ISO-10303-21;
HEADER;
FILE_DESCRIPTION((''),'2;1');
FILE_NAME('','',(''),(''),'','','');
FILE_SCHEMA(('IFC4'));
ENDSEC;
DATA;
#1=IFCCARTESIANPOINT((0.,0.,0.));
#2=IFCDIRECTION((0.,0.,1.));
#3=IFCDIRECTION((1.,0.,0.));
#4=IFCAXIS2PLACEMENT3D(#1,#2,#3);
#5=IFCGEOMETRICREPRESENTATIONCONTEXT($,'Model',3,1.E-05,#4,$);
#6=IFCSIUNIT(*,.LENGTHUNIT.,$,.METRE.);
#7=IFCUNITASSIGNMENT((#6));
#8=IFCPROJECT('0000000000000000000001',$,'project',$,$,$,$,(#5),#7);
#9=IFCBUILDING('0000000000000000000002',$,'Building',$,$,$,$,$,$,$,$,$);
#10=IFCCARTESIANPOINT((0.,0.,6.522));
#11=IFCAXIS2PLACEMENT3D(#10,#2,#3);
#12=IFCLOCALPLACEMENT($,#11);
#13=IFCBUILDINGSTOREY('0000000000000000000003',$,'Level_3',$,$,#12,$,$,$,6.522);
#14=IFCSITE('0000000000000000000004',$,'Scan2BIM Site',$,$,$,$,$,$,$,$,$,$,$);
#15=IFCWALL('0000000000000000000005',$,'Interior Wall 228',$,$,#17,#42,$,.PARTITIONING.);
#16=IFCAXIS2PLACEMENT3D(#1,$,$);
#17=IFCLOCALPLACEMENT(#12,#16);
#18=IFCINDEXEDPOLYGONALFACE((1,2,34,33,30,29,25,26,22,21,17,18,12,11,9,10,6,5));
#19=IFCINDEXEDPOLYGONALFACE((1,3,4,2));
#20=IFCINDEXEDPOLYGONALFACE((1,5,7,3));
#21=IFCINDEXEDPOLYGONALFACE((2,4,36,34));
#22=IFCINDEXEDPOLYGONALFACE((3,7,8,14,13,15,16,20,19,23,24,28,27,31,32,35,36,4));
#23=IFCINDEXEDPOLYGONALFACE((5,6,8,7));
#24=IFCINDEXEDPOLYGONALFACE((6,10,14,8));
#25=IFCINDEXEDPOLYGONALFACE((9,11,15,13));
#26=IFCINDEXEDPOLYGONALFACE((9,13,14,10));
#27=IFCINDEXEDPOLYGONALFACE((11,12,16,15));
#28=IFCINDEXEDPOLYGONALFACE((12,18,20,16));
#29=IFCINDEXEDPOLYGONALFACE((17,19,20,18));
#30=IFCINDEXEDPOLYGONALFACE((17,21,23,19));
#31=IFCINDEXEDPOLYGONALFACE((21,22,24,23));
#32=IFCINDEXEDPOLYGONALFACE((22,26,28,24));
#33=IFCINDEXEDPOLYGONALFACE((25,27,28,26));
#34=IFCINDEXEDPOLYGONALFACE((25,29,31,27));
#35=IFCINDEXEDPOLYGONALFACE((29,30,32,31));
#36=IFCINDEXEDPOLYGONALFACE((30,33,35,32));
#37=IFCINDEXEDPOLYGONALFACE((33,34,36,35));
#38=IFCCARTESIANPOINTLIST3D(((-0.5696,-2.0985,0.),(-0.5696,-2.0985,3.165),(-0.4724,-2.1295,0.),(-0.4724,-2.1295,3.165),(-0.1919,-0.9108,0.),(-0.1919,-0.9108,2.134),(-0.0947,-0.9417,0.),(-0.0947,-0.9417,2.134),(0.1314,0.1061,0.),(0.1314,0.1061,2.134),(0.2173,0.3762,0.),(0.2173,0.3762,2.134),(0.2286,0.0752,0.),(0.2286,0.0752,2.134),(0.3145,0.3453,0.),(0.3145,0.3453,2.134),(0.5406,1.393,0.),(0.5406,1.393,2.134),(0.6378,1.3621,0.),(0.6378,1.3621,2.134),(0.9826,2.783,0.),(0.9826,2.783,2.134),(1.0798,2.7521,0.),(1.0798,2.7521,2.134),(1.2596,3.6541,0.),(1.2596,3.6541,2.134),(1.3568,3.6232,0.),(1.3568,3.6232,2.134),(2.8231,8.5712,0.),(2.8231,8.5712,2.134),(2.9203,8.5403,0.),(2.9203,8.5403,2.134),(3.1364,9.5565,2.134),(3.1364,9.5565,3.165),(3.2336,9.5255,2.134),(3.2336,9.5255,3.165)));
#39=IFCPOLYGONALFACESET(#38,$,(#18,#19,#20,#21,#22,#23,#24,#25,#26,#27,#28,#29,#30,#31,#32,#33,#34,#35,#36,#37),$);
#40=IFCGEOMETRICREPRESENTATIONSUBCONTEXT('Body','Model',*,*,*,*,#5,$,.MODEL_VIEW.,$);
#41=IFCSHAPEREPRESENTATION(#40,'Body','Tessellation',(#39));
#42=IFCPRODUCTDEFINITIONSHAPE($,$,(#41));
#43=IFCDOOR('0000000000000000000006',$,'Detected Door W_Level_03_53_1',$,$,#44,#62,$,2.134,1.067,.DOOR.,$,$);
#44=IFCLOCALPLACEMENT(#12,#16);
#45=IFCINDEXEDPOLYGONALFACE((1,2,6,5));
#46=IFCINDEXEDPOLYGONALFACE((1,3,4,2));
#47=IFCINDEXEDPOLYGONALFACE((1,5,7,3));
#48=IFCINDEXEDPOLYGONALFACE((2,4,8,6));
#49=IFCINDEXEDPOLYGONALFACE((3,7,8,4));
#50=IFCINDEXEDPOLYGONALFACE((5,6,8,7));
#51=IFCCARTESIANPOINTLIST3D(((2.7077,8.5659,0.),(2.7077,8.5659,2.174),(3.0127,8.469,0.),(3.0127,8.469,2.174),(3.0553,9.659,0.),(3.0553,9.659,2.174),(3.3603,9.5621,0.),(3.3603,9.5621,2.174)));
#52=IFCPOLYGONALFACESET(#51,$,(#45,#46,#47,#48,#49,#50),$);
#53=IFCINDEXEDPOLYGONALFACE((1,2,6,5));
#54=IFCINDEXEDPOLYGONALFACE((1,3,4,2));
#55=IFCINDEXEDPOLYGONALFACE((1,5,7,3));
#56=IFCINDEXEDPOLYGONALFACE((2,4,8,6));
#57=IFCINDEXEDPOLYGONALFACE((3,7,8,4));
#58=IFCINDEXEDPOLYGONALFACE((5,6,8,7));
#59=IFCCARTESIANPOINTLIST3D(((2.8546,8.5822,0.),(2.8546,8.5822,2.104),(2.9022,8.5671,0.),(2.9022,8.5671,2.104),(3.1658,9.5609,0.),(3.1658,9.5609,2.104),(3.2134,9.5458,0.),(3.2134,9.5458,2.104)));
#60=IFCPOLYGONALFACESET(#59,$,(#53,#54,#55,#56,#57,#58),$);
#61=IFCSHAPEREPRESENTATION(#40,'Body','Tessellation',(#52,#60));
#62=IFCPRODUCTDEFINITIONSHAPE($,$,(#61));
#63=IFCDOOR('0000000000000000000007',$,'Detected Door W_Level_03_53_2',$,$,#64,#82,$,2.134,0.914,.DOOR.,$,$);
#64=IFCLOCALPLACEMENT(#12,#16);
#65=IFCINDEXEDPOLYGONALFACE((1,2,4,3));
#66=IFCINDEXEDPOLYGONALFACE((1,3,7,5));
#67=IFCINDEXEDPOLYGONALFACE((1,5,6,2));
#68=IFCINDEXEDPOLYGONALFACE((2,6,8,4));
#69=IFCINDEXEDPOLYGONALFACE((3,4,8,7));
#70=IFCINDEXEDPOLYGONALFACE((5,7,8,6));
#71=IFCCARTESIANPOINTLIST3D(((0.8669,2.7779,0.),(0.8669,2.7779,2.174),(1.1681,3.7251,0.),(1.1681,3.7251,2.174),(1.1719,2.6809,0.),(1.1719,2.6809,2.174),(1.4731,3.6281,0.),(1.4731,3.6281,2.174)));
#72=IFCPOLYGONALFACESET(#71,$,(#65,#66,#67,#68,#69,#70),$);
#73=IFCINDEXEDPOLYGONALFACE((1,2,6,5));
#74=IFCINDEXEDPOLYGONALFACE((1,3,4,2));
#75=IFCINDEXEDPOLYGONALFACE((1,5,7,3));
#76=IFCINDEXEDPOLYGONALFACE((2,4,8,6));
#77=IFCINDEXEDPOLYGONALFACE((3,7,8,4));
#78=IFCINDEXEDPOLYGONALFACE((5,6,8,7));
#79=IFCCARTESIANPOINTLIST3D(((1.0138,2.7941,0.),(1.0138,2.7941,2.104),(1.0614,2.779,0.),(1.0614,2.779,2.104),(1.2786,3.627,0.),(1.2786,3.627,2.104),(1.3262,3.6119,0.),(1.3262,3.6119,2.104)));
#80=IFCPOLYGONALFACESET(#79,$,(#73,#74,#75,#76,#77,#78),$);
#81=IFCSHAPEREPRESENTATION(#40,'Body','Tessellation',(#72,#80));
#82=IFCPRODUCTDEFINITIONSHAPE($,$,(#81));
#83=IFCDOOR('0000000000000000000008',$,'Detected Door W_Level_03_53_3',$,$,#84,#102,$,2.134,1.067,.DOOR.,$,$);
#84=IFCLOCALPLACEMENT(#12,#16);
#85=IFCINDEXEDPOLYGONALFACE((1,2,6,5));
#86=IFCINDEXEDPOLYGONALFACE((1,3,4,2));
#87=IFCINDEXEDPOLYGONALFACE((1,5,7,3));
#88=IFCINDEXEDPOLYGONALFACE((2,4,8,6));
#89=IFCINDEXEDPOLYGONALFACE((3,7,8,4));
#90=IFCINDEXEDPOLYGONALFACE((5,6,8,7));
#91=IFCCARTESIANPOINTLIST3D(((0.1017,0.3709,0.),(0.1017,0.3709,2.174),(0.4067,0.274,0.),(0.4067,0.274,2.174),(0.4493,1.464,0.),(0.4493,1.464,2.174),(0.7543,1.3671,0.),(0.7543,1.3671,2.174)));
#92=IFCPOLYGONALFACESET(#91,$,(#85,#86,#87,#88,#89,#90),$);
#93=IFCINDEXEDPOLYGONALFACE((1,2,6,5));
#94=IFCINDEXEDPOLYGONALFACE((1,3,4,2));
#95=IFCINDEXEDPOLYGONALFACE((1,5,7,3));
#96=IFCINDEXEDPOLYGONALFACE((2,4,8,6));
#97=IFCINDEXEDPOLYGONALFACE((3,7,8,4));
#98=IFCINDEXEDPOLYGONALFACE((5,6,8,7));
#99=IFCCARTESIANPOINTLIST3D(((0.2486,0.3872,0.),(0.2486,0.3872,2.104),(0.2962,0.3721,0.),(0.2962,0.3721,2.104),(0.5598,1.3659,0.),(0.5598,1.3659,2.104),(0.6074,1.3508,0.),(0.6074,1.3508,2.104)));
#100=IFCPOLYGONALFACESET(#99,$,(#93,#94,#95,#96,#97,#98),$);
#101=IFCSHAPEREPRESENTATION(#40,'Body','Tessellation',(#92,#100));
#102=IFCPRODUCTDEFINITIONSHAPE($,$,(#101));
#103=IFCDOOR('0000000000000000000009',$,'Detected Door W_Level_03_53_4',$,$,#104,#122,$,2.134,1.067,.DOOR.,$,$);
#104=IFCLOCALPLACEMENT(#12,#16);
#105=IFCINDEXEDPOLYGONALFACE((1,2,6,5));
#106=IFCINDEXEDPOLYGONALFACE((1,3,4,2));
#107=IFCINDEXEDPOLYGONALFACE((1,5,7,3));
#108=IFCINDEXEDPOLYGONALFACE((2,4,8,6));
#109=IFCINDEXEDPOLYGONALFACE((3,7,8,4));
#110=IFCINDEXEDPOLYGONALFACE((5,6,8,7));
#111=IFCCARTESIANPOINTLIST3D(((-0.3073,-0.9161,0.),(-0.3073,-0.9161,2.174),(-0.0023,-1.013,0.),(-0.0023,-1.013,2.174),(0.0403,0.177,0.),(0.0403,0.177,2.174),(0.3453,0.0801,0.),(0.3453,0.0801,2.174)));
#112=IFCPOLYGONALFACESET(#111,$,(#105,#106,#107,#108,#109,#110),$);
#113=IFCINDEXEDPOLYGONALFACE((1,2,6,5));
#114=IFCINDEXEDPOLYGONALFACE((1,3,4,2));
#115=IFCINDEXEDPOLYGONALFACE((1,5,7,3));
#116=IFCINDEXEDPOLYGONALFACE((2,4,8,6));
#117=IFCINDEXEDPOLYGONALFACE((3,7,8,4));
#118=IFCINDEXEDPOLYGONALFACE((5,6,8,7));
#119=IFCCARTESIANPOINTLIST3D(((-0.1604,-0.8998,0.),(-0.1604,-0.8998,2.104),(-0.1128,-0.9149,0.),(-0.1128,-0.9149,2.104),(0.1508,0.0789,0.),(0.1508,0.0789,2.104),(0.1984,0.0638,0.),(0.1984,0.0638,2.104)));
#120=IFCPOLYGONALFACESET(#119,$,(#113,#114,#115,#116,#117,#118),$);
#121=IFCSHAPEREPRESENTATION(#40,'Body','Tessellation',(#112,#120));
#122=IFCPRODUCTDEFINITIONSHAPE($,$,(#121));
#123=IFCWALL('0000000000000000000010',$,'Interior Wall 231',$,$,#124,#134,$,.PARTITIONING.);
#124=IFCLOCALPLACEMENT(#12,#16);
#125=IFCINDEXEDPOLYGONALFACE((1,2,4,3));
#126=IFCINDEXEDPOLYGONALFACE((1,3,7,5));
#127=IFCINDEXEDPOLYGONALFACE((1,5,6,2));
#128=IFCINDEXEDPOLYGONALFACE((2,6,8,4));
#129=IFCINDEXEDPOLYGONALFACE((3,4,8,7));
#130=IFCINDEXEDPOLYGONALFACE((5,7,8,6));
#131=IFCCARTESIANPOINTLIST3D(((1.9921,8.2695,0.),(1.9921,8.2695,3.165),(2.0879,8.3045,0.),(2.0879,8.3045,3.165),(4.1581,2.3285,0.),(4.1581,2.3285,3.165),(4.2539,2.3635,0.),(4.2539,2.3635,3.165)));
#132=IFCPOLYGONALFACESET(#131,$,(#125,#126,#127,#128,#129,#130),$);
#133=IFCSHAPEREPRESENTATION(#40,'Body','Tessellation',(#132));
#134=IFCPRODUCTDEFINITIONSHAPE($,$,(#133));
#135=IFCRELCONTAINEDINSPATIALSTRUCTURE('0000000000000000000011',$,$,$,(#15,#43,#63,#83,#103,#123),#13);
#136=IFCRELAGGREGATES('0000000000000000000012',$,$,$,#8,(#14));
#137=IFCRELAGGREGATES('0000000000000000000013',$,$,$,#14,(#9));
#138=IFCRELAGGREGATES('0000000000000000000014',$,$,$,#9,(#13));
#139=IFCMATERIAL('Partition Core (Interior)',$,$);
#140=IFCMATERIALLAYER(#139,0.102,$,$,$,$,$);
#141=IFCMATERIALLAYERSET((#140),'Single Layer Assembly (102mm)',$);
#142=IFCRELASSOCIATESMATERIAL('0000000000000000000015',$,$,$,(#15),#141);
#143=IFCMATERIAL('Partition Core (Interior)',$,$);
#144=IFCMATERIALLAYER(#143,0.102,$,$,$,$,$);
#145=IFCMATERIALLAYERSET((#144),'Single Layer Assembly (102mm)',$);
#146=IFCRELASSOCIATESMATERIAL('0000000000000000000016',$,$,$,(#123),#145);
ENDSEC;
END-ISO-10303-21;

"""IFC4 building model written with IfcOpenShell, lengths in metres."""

from ifc_helpers import new_model, si_unit, frame, origin, origin_with_axes, place, context, subcontext, project, spatial, rectangle, extrude, material, layer, layer_set, element, fill, save


model = new_model("IFC4")

# Units and contexts
model_context = context("Model", 3, precision=1e-05, world=origin_with_axes())
body_context = subcontext(model_context, "Body", "Model", "MODEL_VIEW")
ifc_project = project(units=[si_unit("LENGTHUNIT", "METRE")], contexts=[model_context])

# Site, building, storey
site = spatial("IfcSite", under=ifc_project, Name="Scan2BIM Site")
building = spatial("IfcBuilding", under=site, Name="Building")
storey_placement = place(None, frame((0.0, 0.0, 6.522), z_axis=(0.0, 0.0, 1.0), x_axis=(1.0, 0.0, 0.0)))
storey = spatial("IfcBuildingStorey", under=building, at=storey_placement, Name="Level_3", Elevation=6.522)

# Wall, openings, doors
ifc_material_1 = material(Name="Partition Core (Interior)")
ifc_layer_1 = layer(ifc_material_1, 0.102)
ifc_layer_set_1 = layer_set([ifc_layer_1], Name="Single Layer Assembly (102mm)")
wall_1_placement = place(storey_placement, frame((1.332, 3.7135, 0.0), z_axis=(0.0, 0.0, 1.0), x_axis=(-0.303025, -0.952983, 0.0)))
wall_1 = element("IfcWall", 1, at=wall_1_placement, inside=storey, material=ifc_layer_set_1, Name="Interior Wall 228", PredefinedType="PARTITIONING", context=body_context, shape_type="SweptSolid", body=[
    extrude(rectangle(XDim=12.23, YDim=0.102), origin(), (0.0, 0.0, 1.0), 3.165),
])
opening_1_placement = place(None, frame((3.034, 9.064, 6.522), z_axis=(0.0, 0.0, 1.0), x_axis=(-0.303025, -0.952983, 0.0)))
opening_1 = element("IfcOpeningElement", 2, at=opening_1_placement, cuts=wall_1, PredefinedType="OPENING", context=body_context, shape_type="SweptSolid", body=[
    extrude(rectangle(XDim=1.067, YDim=0.202), origin(), (0.0, 0.0, 1.0), 2.134),
])
opening_2_placement = place(None, frame((1.17, 3.203, 6.522), z_axis=(0.0, 0.0, 1.0), x_axis=(-0.303025, -0.952983, 0.0)))
opening_2 = element("IfcOpeningElement", 3, at=opening_2_placement, cuts=wall_1, PredefinedType="OPENING", context=body_context, shape_type="SweptSolid", body=[
    extrude(rectangle(XDim=0.914, YDim=0.202), origin(), (0.0, 0.0, 1.0), 2.134),
])
opening_3_placement = place(None, frame((0.428, 0.869, 6.522), z_axis=(0.0, 0.0, 1.0), x_axis=(-0.303025, -0.952983, 0.0)))
opening_3 = element("IfcOpeningElement", 4, at=opening_3_placement, cuts=wall_1, PredefinedType="OPENING", context=body_context, shape_type="SweptSolid", body=[
    extrude(rectangle(XDim=1.067, YDim=0.202), origin(), (0.0, 0.0, 1.0), 2.134),
])
opening_4_placement = place(None, frame((0.019, -0.418, 6.522), z_axis=(0.0, 0.0, 1.0), x_axis=(-0.303025, -0.952983, 0.0)))
opening_4 = element("IfcOpeningElement", 5, at=opening_4_placement, cuts=wall_1, PredefinedType="OPENING", context=body_context, shape_type="SweptSolid", body=[
    extrude(rectangle(XDim=1.067, YDim=0.202), origin(), (0.0, 0.0, 1.0), 2.134),
])
door_1_placement = place(opening_1_placement, frame((0.0, 0.0, 0.0), z_axis=(0.0, 0.0, 1.0), x_axis=(1.0, 0.0, 0.0)))
door_1 = element("IfcDoor", 6, at=door_1_placement, inside=storey, Name="Detected Door W_Level_03_53_1", OverallHeight=2.134, OverallWidth=1.067, PredefinedType="DOOR", context=body_context, shape_type="SweptSolid", body=[
    extrude(rectangle(XDim=1.147, YDim=0.32), origin(), (0.0, 0.0, 1.0), 2.174),
    extrude(rectangle(XDim=1.027, YDim=0.05), origin(), (0.0, 0.0, 1.0), 2.104),
])
fill(opening_1, door_1)
door_2_placement = place(opening_2_placement, frame((0.0, 0.0, 0.0), z_axis=(0.0, 0.0, 1.0), x_axis=(1.0, 0.0, 0.0)))
door_2 = element("IfcDoor", 7, at=door_2_placement, inside=storey, Name="Detected Door W_Level_03_53_2", OverallHeight=2.134, OverallWidth=0.914, PredefinedType="DOOR", context=body_context, shape_type="SweptSolid", body=[
    extrude(rectangle(XDim=0.994, YDim=0.32), origin(), (0.0, 0.0, 1.0), 2.174),
    extrude(rectangle(XDim=0.874, YDim=0.05), origin(), (0.0, 0.0, 1.0), 2.104),
])
fill(opening_2, door_2)
door_3_placement = place(opening_3_placement, frame((0.0, 0.0, 0.0), z_axis=(0.0, 0.0, 1.0), x_axis=(1.0, 0.0, 0.0)))
door_3 = element("IfcDoor", 8, at=door_3_placement, inside=storey, Name="Detected Door W_Level_03_53_3", OverallHeight=2.134, OverallWidth=1.067, PredefinedType="DOOR", context=body_context, shape_type="SweptSolid", body=[
    extrude(rectangle(XDim=1.147, YDim=0.32), origin(), (0.0, 0.0, 1.0), 2.174),
    extrude(rectangle(XDim=1.027, YDim=0.05), origin(), (0.0, 0.0, 1.0), 2.104),
])
fill(opening_3, door_3)
door_4_placement = place(opening_4_placement, frame((0.0, 0.0, 0.0), z_axis=(0.0, 0.0, 1.0), x_axis=(1.0, 0.0, 0.0)))
door_4 = element("IfcDoor", 9, at=door_4_placement, inside=storey, Name="Detected Door W_Level_03_53_4", OverallHeight=2.134, OverallWidth=1.067, PredefinedType="DOOR", context=body_context, shape_type="SweptSolid", body=[
    extrude(rectangle(XDim=1.147, YDim=0.32), origin(), (0.0, 0.0, 1.0), 2.174),
    extrude(rectangle(XDim=1.027, YDim=0.05), origin(), (0.0, 0.0, 1.0), 2.104),
])
fill(opening_4, door_4)

# Wall
ifc_material_2 = material(Name="Partition Core (Interior)")
ifc_layer_2 = layer(ifc_material_2, 0.102)
ifc_layer_set_2 = layer_set([ifc_layer_2], Name="Single Layer Assembly (102mm)")
wall_2_placement = place(storey_placement, frame((3.123, 5.3165, 0.0), z_axis=(0.0, 0.0, 1.0), x_axis=(0.34253, -0.939507, 0.0)))
element("IfcWall", 10, at=wall_2_placement, inside=storey, material=ifc_layer_set_2, Name="Interior Wall 231", PredefinedType="PARTITIONING", context=body_context, shape_type="SweptSolid", body=[
    extrude(rectangle(XDim=6.3235, YDim=0.102), origin(), (0.0, 0.0, 1.0), 3.165),
])

save(model, "model.ifc")
